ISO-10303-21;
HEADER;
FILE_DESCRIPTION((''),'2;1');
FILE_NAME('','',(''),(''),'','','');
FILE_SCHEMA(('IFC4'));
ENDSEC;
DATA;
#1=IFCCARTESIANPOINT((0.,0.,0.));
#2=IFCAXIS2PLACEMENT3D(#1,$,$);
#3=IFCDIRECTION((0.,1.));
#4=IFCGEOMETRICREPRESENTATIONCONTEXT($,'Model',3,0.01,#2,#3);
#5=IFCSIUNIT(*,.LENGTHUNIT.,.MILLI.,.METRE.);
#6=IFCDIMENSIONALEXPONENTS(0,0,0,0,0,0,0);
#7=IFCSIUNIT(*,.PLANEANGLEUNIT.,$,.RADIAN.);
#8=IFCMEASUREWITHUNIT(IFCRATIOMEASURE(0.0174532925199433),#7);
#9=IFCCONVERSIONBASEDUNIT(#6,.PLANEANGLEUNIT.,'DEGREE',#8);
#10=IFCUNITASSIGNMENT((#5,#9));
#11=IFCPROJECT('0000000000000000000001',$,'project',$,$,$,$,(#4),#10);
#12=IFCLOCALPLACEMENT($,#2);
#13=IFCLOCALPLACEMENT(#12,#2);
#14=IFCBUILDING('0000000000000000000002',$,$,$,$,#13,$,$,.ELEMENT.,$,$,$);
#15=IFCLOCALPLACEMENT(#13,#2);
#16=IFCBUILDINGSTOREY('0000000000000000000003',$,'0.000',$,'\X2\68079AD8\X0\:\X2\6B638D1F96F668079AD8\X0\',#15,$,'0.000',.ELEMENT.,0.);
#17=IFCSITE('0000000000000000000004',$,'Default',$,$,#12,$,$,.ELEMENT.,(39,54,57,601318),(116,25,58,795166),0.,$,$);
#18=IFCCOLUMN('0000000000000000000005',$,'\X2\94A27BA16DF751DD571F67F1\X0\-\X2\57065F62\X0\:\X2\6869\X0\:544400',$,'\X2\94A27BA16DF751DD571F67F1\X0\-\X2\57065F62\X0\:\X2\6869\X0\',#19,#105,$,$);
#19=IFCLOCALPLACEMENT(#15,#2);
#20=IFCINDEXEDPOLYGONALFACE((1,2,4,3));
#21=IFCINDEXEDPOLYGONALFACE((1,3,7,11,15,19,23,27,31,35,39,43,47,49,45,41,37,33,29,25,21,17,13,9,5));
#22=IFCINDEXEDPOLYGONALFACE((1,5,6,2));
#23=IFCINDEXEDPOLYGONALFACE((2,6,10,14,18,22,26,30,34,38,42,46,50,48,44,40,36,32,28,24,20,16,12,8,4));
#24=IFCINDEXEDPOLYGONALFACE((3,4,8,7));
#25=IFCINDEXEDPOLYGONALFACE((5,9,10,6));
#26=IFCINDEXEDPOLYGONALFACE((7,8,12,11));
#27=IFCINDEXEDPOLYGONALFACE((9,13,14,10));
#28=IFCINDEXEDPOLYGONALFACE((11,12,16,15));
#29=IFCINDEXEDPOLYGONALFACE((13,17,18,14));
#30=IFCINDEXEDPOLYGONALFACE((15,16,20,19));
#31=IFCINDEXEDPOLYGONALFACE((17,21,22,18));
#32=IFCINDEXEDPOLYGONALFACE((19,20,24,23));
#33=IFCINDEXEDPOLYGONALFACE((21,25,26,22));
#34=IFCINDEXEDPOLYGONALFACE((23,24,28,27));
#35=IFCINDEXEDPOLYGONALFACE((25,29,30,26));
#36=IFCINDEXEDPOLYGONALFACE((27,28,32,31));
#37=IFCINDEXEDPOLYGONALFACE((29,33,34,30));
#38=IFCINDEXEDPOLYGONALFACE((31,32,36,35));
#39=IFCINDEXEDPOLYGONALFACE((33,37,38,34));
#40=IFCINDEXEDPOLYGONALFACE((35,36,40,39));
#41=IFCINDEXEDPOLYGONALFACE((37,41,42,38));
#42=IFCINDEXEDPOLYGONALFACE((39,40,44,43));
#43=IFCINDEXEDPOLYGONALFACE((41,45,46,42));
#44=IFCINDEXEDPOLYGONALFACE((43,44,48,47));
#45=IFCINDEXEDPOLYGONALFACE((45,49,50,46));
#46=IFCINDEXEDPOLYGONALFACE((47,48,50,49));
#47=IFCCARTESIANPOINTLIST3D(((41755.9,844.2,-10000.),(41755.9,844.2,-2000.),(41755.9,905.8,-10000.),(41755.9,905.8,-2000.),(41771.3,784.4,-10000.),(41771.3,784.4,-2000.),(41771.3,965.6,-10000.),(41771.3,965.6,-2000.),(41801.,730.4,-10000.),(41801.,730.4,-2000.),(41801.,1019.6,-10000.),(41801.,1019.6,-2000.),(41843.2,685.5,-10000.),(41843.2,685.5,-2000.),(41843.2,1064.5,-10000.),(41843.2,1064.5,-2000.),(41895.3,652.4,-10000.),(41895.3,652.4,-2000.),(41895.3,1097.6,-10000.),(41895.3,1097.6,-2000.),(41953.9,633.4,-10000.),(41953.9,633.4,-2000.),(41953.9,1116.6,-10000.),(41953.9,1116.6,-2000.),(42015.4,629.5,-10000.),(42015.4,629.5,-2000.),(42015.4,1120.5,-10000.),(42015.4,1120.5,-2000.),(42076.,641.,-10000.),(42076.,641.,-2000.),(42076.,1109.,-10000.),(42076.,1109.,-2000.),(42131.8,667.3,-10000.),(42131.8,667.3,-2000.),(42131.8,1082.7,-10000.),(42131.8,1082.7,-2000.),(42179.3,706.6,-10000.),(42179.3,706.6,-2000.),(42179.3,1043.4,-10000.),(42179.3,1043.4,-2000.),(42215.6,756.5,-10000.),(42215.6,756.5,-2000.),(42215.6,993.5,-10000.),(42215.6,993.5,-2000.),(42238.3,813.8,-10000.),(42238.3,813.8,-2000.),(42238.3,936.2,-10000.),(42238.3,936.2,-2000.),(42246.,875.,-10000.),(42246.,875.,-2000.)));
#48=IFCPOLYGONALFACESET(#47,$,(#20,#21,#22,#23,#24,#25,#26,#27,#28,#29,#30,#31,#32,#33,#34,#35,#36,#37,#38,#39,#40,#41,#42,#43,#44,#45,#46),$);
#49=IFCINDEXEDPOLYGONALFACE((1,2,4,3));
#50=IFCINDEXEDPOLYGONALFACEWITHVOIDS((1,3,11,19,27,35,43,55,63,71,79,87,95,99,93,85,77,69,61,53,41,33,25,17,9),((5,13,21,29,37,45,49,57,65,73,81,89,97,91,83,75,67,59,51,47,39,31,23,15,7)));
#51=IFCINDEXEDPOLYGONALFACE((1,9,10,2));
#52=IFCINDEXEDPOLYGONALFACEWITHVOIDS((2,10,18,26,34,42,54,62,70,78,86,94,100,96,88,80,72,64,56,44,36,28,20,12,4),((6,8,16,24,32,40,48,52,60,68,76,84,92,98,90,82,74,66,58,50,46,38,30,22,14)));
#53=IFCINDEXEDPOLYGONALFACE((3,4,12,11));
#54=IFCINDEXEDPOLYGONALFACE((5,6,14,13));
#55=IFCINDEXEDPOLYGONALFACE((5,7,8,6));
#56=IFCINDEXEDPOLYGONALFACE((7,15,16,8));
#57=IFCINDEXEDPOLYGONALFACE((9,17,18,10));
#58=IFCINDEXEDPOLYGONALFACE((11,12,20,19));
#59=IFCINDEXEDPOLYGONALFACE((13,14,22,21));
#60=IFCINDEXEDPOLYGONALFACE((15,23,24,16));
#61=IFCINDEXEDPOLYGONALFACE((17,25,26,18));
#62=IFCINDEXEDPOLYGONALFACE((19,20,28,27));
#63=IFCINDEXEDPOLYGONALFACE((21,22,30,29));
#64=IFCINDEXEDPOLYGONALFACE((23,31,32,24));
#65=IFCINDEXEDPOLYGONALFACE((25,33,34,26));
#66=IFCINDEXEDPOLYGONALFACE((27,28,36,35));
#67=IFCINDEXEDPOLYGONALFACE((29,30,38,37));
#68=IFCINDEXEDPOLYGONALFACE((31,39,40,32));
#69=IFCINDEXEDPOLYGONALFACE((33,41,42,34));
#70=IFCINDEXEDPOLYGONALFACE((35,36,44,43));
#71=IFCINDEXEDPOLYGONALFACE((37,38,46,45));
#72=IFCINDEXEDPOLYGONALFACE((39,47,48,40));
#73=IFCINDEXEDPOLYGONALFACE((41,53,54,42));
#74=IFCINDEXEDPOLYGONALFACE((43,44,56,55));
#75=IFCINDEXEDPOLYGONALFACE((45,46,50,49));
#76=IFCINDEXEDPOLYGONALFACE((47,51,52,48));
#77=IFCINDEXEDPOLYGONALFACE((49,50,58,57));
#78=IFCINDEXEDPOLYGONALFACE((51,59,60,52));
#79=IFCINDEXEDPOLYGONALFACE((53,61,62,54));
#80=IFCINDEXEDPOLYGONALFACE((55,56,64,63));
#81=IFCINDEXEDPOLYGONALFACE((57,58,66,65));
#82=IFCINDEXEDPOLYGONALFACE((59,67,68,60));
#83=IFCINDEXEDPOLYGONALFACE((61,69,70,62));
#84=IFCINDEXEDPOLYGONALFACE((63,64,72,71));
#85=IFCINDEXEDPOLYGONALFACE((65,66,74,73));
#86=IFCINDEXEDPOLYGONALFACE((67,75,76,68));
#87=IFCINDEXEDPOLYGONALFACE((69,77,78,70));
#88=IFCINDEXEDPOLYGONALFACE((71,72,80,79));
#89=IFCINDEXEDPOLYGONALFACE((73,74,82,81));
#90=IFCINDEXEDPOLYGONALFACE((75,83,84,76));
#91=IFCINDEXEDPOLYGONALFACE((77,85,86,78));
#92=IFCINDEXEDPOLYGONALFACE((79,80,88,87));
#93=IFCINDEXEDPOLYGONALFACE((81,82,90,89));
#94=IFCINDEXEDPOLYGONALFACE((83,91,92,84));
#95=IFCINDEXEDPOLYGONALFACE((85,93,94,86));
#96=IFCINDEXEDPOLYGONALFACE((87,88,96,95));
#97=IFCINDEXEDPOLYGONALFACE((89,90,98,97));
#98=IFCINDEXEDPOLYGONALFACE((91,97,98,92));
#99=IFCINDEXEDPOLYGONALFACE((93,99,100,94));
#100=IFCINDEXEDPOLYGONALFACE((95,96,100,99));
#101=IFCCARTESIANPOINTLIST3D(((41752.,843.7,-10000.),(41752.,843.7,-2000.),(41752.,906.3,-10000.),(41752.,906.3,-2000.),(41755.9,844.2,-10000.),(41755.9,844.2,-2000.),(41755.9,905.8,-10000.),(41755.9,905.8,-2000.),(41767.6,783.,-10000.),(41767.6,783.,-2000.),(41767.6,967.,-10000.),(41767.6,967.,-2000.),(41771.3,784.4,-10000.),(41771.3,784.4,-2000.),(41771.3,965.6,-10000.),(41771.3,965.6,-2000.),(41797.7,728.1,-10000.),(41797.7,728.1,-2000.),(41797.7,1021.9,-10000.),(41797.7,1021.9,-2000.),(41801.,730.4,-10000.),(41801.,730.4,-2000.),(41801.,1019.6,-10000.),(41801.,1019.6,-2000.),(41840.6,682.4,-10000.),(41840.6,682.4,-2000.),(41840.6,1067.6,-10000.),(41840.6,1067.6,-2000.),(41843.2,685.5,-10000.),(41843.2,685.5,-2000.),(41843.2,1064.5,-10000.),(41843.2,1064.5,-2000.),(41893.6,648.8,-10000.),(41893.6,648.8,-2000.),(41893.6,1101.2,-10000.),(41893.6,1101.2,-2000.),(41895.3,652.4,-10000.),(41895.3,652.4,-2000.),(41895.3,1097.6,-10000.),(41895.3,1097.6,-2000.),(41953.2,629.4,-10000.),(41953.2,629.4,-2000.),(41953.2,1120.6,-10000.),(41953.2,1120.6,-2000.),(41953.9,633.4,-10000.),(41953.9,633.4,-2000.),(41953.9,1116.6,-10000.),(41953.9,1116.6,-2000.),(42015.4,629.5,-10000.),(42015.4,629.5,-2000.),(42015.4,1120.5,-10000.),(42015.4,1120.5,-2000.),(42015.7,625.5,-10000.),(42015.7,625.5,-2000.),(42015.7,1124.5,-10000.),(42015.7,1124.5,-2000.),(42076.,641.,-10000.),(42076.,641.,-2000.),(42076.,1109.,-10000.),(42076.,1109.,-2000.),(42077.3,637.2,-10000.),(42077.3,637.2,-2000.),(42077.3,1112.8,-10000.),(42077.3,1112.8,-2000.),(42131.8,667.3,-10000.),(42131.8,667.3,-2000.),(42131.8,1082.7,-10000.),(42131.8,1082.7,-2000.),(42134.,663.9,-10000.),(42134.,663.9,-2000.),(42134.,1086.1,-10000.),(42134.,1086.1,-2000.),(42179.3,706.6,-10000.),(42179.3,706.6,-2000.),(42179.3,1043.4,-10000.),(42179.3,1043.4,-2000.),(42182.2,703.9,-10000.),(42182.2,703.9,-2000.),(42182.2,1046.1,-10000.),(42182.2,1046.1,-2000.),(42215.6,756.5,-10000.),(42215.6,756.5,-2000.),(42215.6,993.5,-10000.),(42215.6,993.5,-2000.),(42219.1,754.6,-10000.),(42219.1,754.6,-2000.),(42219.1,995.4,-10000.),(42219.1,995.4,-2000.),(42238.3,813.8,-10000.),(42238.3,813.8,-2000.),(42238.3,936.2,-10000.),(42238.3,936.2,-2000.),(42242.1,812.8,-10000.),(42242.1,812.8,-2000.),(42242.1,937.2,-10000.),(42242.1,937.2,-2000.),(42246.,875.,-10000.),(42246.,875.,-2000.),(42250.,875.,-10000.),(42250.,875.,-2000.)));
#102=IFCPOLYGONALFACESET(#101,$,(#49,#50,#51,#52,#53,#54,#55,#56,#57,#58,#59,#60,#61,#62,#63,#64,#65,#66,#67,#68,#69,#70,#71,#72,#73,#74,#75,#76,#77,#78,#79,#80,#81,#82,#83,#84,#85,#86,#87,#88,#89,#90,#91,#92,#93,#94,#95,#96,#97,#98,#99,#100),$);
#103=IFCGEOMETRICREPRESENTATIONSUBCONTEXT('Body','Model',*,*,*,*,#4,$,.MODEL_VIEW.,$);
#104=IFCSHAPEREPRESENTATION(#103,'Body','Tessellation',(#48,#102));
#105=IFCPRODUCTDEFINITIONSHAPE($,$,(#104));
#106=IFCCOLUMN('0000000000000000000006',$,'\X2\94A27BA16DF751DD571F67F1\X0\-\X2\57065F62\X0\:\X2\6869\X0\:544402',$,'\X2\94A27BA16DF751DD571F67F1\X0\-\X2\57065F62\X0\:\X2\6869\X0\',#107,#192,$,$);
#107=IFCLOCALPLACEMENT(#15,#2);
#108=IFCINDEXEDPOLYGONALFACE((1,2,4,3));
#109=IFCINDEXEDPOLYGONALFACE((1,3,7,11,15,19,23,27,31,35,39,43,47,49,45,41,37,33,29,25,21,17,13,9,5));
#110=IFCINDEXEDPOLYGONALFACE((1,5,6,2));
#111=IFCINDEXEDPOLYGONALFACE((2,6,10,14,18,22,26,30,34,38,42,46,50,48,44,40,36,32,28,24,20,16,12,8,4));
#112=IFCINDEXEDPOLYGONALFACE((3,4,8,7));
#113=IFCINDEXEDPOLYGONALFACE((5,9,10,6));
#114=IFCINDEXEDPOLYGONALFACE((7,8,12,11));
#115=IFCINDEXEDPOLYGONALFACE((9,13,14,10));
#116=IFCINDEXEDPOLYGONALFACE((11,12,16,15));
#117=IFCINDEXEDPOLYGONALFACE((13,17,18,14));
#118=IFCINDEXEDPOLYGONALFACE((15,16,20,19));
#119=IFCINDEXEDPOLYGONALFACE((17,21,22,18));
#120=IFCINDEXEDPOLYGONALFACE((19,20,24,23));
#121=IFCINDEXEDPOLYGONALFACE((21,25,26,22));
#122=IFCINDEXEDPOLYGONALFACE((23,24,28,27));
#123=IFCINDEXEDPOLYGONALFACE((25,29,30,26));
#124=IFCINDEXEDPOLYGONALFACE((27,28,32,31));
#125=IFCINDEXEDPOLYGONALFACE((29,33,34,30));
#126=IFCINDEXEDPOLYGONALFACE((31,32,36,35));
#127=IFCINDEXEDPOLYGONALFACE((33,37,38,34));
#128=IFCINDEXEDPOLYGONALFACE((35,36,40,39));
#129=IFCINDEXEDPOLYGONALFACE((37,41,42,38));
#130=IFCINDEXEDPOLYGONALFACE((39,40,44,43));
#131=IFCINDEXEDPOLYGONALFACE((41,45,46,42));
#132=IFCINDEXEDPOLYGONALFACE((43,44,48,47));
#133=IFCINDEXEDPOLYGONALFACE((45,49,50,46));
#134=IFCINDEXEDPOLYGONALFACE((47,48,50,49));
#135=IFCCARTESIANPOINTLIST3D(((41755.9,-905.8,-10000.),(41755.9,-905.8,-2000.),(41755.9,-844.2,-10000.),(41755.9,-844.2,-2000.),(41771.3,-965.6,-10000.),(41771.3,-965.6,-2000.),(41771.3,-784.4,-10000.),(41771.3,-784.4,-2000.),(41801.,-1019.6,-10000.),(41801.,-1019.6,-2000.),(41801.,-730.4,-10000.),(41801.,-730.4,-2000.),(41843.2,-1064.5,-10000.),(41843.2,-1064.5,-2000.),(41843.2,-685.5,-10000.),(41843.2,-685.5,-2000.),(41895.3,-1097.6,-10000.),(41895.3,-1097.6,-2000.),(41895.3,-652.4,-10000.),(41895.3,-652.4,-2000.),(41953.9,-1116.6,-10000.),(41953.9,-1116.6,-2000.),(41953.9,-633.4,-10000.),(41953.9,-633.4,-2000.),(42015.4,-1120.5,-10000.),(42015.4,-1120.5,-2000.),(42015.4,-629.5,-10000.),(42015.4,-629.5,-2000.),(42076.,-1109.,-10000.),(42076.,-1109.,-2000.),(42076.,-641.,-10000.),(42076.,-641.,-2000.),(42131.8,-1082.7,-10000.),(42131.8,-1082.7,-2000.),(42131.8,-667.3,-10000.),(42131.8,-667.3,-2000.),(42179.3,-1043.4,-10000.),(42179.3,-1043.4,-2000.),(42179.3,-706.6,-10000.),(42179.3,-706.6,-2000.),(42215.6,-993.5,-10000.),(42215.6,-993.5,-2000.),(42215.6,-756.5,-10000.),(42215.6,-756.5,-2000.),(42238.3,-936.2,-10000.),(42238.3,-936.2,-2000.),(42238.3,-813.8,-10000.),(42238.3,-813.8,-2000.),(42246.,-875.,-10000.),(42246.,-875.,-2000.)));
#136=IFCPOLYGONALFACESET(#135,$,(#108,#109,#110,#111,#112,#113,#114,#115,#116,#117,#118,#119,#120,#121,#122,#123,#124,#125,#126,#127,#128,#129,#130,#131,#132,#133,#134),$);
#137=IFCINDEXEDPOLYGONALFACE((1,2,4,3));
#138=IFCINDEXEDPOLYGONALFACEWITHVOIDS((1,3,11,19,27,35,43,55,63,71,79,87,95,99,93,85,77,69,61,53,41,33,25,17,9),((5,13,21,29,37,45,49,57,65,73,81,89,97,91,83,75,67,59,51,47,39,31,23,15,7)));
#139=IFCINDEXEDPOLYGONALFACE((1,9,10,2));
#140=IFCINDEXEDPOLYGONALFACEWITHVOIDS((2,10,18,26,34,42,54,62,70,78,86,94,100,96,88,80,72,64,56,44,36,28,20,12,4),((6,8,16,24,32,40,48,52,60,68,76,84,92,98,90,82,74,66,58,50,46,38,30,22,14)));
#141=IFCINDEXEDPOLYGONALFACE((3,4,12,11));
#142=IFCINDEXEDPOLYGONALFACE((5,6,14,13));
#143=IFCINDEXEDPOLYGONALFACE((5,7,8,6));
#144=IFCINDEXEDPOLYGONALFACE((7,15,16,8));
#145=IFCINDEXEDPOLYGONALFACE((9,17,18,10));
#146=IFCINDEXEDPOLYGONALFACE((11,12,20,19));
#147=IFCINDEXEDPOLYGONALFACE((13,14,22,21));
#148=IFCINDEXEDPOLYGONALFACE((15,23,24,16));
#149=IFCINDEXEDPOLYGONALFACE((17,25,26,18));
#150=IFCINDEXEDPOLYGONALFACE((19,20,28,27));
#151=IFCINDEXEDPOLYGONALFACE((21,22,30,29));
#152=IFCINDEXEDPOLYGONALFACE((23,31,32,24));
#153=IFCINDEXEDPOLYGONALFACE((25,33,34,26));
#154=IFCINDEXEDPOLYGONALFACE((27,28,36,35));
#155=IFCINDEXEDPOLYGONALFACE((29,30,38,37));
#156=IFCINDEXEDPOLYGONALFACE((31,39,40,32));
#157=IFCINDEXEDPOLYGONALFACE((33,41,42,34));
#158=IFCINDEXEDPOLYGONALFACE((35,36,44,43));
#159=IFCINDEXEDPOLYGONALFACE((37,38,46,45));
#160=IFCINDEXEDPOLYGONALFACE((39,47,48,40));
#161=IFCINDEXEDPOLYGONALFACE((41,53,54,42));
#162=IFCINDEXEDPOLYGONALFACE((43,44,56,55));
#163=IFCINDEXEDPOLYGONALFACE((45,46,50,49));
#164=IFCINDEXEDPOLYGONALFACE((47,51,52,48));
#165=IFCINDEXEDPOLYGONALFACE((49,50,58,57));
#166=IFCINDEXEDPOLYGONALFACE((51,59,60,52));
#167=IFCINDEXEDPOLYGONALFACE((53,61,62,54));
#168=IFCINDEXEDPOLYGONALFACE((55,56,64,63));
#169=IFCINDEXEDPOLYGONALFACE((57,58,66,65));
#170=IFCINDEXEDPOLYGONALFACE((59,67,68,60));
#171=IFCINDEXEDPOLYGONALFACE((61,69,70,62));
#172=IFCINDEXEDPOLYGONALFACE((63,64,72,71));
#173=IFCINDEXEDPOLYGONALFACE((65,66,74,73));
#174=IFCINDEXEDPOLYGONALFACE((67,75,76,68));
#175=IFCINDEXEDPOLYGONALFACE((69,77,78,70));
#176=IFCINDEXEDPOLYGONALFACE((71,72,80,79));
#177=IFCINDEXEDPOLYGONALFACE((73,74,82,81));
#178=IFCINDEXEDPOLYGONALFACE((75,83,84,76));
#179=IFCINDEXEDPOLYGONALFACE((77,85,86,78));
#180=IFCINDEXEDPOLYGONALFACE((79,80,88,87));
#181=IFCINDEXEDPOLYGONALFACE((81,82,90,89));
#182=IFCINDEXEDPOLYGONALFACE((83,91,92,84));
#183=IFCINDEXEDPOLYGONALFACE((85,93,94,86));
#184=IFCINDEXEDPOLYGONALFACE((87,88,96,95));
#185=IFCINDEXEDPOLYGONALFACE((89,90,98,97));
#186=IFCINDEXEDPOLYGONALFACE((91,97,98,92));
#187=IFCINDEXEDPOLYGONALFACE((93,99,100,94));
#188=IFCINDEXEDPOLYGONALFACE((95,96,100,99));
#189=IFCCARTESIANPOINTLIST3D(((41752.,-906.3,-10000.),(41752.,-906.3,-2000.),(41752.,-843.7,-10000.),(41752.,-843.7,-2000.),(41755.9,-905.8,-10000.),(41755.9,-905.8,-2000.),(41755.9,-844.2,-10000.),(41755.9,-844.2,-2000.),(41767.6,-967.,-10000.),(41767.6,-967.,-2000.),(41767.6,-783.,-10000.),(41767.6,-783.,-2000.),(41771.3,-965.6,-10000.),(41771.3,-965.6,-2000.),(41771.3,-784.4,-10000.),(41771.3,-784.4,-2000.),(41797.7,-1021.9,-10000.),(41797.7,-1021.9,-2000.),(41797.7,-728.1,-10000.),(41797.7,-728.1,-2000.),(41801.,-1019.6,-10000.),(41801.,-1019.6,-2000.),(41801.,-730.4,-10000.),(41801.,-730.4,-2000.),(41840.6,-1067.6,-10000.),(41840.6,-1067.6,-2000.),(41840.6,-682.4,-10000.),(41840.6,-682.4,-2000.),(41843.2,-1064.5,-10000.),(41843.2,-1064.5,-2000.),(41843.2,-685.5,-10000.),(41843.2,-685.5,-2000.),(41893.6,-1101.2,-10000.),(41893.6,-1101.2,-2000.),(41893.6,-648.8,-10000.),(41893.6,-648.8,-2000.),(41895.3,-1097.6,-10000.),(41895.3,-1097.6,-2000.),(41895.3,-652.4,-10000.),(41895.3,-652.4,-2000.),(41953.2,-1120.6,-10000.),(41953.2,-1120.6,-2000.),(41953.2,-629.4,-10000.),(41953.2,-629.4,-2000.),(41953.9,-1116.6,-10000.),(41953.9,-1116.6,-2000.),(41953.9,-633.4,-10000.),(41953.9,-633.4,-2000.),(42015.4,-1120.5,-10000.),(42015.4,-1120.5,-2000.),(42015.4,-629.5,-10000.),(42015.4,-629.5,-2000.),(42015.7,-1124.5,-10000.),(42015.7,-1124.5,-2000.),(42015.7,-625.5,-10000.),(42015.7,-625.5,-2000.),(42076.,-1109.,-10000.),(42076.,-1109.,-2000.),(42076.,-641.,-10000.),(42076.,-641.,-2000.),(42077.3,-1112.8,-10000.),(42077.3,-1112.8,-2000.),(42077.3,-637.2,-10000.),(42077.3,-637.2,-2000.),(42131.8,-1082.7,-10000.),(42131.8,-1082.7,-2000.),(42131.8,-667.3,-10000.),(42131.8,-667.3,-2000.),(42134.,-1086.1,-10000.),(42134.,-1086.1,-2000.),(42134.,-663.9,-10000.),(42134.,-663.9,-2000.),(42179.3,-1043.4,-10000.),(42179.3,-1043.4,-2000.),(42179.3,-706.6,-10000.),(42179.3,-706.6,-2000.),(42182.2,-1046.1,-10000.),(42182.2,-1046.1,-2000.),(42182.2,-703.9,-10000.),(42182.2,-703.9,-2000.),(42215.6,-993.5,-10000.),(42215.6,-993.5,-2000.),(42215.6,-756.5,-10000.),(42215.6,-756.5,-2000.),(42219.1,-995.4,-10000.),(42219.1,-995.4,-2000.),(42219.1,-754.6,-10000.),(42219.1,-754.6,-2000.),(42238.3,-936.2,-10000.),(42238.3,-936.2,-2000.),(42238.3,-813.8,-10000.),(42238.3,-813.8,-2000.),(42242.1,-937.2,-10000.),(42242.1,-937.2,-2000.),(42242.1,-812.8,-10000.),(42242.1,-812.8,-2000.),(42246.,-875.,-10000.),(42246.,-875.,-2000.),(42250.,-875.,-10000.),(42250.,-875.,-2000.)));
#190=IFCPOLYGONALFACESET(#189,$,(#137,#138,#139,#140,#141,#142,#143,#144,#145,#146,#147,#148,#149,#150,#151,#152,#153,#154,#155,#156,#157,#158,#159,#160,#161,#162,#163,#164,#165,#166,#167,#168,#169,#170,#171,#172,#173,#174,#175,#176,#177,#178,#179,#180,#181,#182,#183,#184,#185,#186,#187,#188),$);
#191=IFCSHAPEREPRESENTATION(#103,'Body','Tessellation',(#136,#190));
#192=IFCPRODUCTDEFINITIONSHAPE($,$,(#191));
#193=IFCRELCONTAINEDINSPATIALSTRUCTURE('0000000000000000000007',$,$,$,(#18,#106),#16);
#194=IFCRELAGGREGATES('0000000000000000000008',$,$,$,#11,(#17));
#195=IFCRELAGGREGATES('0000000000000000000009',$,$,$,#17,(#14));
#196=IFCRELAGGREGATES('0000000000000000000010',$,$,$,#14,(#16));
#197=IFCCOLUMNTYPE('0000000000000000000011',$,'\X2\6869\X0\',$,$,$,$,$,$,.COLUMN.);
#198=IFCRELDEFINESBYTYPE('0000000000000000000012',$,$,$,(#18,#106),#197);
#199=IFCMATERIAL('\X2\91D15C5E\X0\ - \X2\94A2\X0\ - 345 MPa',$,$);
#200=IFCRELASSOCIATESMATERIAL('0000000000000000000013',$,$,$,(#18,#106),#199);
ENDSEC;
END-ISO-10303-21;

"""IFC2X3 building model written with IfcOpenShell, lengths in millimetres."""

from ifc_helpers import new_model, entity, si_unit, converted_unit, direction, frame, frame_2d, origin, place, context, subcontext, project, spatial, circle, hollow_circle, extrude, source, transform, mapped, material, type_object, type_shapes, element, save


model = new_model("IFC2X3")

# Units and contexts
model_context = context("Model", 3, precision=0.01, world=origin(), true_north=direction((0.0, 1.0)))
body_context = subcontext(model_context, "Body", "Model", "MODEL_VIEW")
ifc_project = project(units=[si_unit("LENGTHUNIT", "METRE", prefix="MILLI"), converted_unit("PLANEANGLEUNIT", "DEGREE", entity("IfcRatioMeasure", 0.0174532925199433), si_unit("PLANEANGLEUNIT", "RADIAN"), dimensions=[0, 0, 0, 0, 0, 0, 0])], contexts=[model_context])

# Site, building, storey
site_placement = place(None, origin())
site = spatial("IfcSite", under=ifc_project, at=site_placement, Name="Default", CompositionType="ELEMENT", RefLatitude=(39, 54, 57, 601318), RefLongitude=(116, 25, 58, 795166), RefElevation=0.0)
building_placement = place(site_placement, origin())
building = spatial("IfcBuilding", under=site, at=building_placement, CompositionType="ELEMENT")
storey_placement = place(building_placement, origin())
storey = spatial("IfcBuildingStorey", under=building, at=storey_placement, Name="0.000", ObjectType="标高:正负零标高", LongName="0.000", CompositionType="ELEMENT", Elevation=0.0)

# Columns
ifc_material_1 = material(Name="金属 - 钢 - 345 MPa")
column_type = type_object("IfcColumnType", Name="桩", PredefinedType="COLUMN")
shared_shape = source(origin(), body_context, "Body", "SweptSolid", [
    extrude(circle(Radius=246.0, at=frame_2d((0.0, 0.0), x_axis=(1.0, 0.0))), frame((0.0, 0.0, -10000.0)), (0.0, 0.0, 1.0), 8000.0),
    extrude(hollow_circle(Radius=250.0, WallThickness=4.0, at=frame_2d((0.0, 0.0), x_axis=(1.0, 0.0))), frame((0.0, 0.0, -10000.0)), (0.0, 0.0, 1.0), 8000.0),
])
type_shapes(column_type, [shared_shape])
for number, where, name in (
    (1, (42000.0, 875.0, 0.0), "钢管混凝土柱-圆形:桩:544400"),
    (2, (42000.0, -875.0, 0.0), "钢管混凝土柱-圆形:桩:544402"),
):
    element("IfcColumn", number, at=place(storey_placement, frame(where)), inside=storey, type_object=column_type, material=ifc_material_1, Name=name, ObjectType="钢管混凝土柱-圆形:桩", context=body_context, shape_type="MappedRepresentation", body=[
        mapped(shared_shape, transform((0.0, 0.0, 0.0), scale=1.0)),
    ])

save(model, "model.ifc")
